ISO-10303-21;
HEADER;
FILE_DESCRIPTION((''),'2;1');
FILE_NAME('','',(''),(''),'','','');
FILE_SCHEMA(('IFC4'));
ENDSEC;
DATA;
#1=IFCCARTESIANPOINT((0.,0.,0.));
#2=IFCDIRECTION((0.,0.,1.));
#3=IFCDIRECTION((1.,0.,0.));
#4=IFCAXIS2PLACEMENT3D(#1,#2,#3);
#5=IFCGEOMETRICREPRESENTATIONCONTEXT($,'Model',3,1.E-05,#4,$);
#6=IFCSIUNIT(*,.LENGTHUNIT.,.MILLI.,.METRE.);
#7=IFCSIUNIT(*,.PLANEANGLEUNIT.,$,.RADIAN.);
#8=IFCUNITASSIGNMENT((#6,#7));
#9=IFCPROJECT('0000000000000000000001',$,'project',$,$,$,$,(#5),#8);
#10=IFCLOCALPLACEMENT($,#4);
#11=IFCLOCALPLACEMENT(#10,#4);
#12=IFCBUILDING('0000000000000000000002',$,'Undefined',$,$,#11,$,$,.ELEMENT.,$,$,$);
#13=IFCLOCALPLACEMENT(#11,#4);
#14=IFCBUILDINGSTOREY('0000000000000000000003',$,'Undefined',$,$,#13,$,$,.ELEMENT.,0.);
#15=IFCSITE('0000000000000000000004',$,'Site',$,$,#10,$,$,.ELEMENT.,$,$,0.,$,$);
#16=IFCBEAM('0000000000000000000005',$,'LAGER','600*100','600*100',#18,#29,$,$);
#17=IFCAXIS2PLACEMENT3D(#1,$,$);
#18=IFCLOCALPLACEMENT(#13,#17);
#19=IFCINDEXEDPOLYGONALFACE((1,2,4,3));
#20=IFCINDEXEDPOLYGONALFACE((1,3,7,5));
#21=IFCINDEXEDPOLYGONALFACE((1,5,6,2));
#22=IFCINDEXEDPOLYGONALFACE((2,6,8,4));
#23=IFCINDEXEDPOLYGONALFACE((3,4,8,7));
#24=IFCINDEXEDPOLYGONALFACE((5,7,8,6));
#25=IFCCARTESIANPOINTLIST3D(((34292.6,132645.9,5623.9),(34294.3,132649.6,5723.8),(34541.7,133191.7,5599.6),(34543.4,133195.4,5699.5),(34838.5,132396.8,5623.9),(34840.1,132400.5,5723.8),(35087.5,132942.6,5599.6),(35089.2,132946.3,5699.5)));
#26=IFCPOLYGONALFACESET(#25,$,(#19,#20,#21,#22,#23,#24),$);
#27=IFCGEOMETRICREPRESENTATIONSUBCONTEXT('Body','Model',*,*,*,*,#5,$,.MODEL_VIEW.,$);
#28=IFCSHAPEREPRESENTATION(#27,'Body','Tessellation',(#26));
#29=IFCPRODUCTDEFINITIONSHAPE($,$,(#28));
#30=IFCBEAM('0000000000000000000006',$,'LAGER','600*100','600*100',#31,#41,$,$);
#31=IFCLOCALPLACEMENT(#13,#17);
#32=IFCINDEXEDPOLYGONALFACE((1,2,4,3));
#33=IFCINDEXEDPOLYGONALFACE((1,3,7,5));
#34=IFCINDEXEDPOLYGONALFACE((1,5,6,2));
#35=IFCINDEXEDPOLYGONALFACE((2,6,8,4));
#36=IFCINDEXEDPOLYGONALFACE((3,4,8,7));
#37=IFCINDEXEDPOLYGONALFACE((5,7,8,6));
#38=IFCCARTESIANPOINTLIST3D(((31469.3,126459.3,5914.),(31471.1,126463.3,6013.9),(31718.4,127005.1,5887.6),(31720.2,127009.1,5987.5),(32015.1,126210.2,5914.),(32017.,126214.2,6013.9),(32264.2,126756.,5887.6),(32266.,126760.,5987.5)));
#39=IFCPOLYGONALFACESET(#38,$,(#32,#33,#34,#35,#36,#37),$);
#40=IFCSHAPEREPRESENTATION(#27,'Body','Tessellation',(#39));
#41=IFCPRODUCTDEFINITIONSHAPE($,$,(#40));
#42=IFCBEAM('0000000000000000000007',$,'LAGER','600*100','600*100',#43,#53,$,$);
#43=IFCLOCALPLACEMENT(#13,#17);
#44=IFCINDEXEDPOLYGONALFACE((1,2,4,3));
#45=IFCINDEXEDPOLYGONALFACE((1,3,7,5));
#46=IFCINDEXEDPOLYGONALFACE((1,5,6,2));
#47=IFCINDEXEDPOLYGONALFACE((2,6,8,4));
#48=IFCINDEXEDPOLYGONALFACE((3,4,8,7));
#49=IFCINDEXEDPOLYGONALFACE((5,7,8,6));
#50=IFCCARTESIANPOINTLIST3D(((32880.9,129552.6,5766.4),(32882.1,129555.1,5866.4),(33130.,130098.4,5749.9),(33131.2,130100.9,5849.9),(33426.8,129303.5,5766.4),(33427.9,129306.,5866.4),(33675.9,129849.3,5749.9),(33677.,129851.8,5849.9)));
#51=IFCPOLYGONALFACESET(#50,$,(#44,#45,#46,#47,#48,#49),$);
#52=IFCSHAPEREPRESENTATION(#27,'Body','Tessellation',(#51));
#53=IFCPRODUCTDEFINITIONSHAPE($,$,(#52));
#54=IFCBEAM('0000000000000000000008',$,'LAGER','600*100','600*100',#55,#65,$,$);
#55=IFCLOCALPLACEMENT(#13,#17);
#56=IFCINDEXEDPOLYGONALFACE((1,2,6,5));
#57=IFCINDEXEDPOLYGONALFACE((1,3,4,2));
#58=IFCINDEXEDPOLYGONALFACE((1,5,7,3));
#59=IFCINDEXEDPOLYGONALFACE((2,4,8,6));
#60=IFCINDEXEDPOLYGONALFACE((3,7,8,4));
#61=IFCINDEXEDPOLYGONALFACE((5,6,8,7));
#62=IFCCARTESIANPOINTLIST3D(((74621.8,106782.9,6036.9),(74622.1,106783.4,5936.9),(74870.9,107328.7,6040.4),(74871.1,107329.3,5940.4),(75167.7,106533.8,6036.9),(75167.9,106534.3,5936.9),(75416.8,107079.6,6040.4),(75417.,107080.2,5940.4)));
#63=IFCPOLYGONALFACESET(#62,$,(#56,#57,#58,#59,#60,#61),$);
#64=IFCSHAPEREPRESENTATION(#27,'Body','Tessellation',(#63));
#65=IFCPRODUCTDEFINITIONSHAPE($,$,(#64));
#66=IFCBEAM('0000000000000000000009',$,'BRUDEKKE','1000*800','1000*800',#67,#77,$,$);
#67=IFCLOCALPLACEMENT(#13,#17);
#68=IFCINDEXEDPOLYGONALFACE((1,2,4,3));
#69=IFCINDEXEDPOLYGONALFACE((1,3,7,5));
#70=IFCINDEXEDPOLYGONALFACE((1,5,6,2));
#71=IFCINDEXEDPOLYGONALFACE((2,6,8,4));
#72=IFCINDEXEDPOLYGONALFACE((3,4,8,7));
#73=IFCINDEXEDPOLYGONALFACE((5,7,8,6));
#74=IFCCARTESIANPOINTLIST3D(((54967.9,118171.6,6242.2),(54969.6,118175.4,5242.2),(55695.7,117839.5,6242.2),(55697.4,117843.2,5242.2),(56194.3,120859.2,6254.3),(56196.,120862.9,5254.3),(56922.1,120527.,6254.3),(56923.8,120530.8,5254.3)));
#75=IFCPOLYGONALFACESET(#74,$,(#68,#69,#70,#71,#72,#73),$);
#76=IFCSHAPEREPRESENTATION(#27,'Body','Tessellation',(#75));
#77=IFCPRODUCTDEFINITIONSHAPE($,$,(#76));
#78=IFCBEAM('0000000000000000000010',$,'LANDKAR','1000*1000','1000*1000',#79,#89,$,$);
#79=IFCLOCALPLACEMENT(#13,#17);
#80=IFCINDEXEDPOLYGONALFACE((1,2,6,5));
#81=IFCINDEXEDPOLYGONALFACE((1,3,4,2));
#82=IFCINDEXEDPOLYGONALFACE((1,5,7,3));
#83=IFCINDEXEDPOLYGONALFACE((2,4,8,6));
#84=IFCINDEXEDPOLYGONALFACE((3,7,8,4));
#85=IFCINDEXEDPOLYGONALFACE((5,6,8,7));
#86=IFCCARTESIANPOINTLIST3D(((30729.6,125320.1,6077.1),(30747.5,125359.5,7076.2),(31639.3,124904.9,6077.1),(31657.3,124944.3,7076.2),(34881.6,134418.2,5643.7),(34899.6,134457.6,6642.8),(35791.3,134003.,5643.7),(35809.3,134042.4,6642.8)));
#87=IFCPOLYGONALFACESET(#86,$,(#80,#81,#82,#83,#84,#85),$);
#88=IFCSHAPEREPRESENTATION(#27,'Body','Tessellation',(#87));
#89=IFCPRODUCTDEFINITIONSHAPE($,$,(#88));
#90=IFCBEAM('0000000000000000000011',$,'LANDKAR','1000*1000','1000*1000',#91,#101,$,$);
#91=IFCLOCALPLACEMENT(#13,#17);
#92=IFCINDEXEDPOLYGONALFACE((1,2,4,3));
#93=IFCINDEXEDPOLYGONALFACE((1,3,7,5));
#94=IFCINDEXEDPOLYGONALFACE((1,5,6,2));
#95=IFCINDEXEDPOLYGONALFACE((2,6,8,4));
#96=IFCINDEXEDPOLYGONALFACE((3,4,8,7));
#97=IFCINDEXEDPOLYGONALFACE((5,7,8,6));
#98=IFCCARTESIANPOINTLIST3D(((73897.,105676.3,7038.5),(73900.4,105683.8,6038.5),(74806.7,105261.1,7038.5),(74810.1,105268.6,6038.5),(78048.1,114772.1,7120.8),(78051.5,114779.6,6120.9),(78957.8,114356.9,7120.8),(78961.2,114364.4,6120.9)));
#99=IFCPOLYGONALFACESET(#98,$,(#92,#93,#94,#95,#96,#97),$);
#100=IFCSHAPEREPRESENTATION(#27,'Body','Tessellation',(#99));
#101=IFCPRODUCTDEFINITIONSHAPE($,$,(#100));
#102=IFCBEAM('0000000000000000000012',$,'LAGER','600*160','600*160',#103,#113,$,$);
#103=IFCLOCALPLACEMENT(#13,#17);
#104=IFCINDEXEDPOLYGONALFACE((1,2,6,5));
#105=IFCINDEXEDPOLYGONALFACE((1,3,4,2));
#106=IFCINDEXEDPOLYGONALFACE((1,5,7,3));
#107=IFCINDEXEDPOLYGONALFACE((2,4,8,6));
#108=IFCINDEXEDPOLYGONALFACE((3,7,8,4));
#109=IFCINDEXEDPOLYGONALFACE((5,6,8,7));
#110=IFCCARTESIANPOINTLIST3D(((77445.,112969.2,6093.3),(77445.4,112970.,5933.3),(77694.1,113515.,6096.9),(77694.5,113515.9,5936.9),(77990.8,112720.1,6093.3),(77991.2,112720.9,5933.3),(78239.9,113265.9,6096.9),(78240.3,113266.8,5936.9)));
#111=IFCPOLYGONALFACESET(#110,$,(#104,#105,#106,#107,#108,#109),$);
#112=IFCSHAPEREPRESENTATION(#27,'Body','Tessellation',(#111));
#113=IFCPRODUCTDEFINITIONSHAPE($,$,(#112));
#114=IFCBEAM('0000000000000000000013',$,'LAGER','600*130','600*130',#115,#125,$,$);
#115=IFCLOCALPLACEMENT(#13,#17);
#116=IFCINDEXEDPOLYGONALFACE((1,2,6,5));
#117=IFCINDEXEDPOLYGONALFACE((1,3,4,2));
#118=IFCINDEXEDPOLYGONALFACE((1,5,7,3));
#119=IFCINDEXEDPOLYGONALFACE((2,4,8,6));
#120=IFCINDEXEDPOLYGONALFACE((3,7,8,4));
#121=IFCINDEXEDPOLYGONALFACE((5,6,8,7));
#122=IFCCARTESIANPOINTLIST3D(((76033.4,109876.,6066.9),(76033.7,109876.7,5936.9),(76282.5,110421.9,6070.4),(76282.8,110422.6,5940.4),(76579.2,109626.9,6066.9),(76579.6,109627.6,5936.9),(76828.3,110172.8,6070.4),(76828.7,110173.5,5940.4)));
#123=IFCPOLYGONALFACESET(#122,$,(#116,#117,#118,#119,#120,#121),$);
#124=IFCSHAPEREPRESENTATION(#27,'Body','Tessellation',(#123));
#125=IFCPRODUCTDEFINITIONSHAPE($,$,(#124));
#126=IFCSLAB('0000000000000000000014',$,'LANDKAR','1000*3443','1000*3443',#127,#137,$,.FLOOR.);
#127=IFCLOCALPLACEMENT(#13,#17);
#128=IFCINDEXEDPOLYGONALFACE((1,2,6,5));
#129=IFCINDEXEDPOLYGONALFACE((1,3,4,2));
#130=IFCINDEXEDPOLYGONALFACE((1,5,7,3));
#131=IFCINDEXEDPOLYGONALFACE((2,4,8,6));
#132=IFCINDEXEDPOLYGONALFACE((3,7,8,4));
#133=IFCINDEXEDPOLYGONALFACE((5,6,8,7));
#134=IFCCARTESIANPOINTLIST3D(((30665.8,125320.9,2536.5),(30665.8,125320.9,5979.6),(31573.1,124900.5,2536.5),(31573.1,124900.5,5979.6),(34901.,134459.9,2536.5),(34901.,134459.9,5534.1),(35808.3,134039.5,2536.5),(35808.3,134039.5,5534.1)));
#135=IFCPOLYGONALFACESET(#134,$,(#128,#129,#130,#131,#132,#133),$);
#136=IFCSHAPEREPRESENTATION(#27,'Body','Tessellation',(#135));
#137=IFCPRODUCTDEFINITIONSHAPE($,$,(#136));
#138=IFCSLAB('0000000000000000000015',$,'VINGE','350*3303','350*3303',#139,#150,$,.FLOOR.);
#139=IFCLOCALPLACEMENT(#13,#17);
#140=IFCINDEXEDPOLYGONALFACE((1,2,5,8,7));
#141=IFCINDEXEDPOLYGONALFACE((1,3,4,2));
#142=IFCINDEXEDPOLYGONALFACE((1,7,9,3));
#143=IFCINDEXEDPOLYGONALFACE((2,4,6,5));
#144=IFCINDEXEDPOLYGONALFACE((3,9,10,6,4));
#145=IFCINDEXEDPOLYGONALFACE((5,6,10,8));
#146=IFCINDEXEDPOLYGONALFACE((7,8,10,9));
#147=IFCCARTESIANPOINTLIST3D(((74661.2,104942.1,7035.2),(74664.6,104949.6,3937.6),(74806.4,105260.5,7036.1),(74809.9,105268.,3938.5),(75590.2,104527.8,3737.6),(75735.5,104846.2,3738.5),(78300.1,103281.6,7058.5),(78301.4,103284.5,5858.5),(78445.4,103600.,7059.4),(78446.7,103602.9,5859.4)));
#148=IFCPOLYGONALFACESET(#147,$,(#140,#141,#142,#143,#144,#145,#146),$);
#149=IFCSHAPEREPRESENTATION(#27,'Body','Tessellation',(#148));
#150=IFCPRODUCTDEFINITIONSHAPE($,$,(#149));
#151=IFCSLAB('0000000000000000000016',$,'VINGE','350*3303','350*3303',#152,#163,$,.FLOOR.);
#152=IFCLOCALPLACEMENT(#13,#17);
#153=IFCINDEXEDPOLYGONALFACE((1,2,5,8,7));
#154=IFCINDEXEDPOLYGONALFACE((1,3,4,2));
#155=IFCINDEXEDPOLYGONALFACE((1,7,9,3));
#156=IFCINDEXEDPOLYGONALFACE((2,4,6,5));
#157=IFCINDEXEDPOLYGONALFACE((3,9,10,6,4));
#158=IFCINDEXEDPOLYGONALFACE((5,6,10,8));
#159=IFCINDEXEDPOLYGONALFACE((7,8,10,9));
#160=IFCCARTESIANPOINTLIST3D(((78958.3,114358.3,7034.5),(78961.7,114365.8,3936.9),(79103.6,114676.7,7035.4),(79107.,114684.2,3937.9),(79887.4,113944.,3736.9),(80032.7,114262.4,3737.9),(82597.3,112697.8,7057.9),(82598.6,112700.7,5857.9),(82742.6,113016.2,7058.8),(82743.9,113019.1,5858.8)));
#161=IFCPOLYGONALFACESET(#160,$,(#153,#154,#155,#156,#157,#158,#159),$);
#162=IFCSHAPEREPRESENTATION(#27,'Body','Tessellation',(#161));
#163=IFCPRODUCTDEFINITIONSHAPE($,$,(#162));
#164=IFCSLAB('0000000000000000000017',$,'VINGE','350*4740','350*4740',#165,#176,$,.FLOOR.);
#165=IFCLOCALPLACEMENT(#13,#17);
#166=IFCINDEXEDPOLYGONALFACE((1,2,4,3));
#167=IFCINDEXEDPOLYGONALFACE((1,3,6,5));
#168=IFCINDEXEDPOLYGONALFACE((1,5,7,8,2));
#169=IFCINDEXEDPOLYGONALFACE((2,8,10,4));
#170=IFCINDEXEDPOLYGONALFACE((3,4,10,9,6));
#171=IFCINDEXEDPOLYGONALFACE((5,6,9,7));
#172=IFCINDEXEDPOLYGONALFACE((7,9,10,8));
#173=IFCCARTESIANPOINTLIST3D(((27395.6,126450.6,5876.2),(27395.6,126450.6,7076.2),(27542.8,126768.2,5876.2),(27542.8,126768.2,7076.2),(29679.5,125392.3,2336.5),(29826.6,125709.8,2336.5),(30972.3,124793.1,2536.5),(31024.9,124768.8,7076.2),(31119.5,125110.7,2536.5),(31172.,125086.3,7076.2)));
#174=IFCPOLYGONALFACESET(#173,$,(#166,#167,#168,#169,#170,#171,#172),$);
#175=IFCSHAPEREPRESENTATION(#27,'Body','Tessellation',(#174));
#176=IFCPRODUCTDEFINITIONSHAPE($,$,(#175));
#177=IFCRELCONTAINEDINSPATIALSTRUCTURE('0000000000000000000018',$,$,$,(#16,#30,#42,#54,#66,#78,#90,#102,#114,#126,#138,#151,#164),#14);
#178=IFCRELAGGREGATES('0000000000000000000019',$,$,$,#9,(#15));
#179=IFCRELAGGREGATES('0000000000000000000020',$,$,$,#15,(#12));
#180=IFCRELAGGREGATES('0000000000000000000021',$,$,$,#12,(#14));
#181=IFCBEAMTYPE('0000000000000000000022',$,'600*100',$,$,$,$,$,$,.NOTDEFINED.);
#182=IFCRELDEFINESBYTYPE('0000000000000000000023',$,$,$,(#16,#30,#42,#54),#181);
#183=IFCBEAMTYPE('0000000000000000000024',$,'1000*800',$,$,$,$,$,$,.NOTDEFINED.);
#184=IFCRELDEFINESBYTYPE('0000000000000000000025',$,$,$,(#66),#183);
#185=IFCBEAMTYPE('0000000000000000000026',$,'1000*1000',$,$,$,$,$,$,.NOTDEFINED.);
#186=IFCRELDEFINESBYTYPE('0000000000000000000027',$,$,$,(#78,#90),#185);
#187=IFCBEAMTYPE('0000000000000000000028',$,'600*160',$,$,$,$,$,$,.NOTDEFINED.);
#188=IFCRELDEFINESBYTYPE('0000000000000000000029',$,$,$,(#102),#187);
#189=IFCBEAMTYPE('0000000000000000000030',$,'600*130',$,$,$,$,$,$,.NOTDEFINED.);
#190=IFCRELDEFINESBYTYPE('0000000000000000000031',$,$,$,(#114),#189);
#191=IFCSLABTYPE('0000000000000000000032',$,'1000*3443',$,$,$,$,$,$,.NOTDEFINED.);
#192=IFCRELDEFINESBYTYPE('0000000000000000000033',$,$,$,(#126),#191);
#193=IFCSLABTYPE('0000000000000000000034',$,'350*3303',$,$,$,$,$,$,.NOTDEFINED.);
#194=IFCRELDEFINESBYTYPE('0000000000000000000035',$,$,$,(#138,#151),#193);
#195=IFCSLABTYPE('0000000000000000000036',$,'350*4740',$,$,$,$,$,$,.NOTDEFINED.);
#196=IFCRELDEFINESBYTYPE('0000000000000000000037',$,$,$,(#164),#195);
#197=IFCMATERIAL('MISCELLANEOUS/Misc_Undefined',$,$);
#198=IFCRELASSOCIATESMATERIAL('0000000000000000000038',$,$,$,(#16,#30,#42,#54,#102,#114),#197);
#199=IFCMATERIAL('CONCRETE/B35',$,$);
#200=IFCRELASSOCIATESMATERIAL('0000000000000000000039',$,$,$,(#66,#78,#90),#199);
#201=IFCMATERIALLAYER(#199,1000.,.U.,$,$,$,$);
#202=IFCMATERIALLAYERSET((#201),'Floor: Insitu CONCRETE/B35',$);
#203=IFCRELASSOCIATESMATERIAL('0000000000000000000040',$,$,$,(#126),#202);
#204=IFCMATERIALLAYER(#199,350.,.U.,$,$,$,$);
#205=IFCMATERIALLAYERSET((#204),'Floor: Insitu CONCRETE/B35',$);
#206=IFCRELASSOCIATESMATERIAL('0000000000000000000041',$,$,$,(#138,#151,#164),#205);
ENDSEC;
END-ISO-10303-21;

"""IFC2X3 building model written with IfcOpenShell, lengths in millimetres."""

from ifc_helpers import new_model, si_unit, frame, origin_with_axes, origin_2d_with_axis, place, context, subcontext, project, spatial, polyline, rectangle, outline, extrude, material, layer, layer_set, layer_usage, type_object, element, save


model = new_model("IFC2X3")

# Units and contexts
model_context = context("Model", 3, precision=1e-05, world=origin_with_axes())
body_context = subcontext(model_context, "Body", "Model", "MODEL_VIEW")
ifc_project = project(units=[si_unit("LENGTHUNIT", "METRE", prefix="MILLI"), si_unit("PLANEANGLEUNIT", "RADIAN")], contexts=[model_context])

# Site, building, storey
site_placement = place(None, origin_with_axes())
site = spatial("IfcSite", under=ifc_project, at=site_placement, Name="Site", CompositionType="ELEMENT", RefElevation=0.0)
building_placement = place(site_placement, origin_with_axes())
building = spatial("IfcBuilding", under=site, at=building_placement, Name="Undefined", CompositionType="ELEMENT")
storey_placement = place(building_placement, origin_with_axes())
storey = spatial("IfcBuildingStorey", under=building, at=storey_placement, Name="Undefined", CompositionType="ELEMENT", Elevation=0.0)

# Shared definitions
ifc_material_1 = material(Name="CONCRETE/B35")

# Beams
ifc_material_2 = material(Name="MISCELLANEOUS/Misc_Undefined")
beam_type_1 = type_object("IfcBeamType", Name="600*100", PredefinedType="NOTDEFINED")
beam_1_placement = place(storey_placement, frame((34566.4, 132523.2, 5673.9), z_axis=(-0.90975, 0.415157, 0.0), x_axis=(0.414817, 0.909004, -0.040476)))
element("IfcBeam", 1, at=beam_1_placement, inside=storey, type_object=beam_type_1, material=ifc_material_2, Name="LAGER", Description="600*100", ObjectType="600*100", context=body_context, shape_type="SweptSolid", body=[
    extrude(rectangle(XDim=100.0, YDim=600.0, at=origin_2d_with_axis()), frame((600.5, 0.0, 0.0), z_axis=(-1.0, 0.0, 0.0), x_axis=(0.0, -1.0, 0.0)), (0.0, 0.0, 1.0), 600.5),
])
beam_2_placement = place(storey_placement, frame((31743.1, 126336.7, 5963.9), z_axis=(-0.90975, 0.415157, 0.0), x_axis=(0.414758, 0.908875, -0.043844)))
element("IfcBeam", 2, at=beam_2_placement, inside=storey, type_object=beam_type_1, material=ifc_material_2, Name="LAGER", Description="600*100", ObjectType="600*100", context=body_context, shape_type="SweptSolid", body=[
    extrude(rectangle(XDim=100.0, YDim=600.0, at=origin_2d_with_axis()), frame((600.6, 0.0, 0.0), z_axis=(-1.0, 0.0, 0.0), x_axis=(0.0, -1.0, 0.0)), (0.0, 0.0, 1.0), 600.6),
])
beam_3_placement = place(storey_placement, frame((33154.4, 129429.3, 5816.4), z_axis=(-0.90975, 0.415157, 0.0), x_axis=(0.415001, 0.909407, -0.027434)))
element("IfcBeam", 3, at=beam_3_placement, inside=storey, type_object=beam_type_1, material=ifc_material_2, Name="LAGER", Description="600*100", ObjectType="600*100", context=body_context, shape_type="SweptSolid", body=[
    extrude(rectangle(XDim=100.0, YDim=600.0, at=origin_2d_with_axis()), frame((600.2, 0.0, 0.0), z_axis=(-1.0, 0.0, 0.0), x_axis=(0.0, -1.0, 0.0)), (0.0, 0.0, 1.0), 600.2),
])
beam_4_placement = place(storey_placement, frame((74894.9, 106658.6, 5986.9), z_axis=(-0.90975, 0.415157, 0.0), x_axis=(0.41515, 0.909734, 0.005889)))
element("IfcBeam", 4, at=beam_4_placement, inside=storey, type_object=beam_type_1, material=ifc_material_2, Name="LAGER", Description="600*100", ObjectType="600*100", context=body_context, shape_type="SweptSolid", body=[
    extrude(rectangle(XDim=100.0, YDim=600.0, at=origin_2d_with_axis()), frame((600.0, 0.0, 0.0), z_axis=(-1.0, 0.0, 0.0), x_axis=(0.0, -1.0, 0.0)), (0.0, 0.0, 1.0), 600.0),
])
beam_type_2 = type_object("IfcBeamType", Name="1000*800", PredefinedType="NOTDEFINED")
beam_5_placement = place(storey_placement, frame((55332.6, 118007.4, 5742.2), z_axis=(-0.001706, -0.003738, 0.999992), x_axis=(0.415154, 0.909742, 0.004109)))
element("IfcBeam", 5, at=beam_5_placement, inside=storey, type_object=beam_type_2, material=ifc_material_1, Name="BRUDEKKE", Description="1000*800", ObjectType="1000*800", context=body_context, shape_type="SweptSolid", body=[
    extrude(rectangle(XDim=800.0, YDim=1000.0, at=origin_2d_with_axis()), frame((2954.2, 0.0, 0.0), z_axis=(-1.0, 0.0, 0.0), x_axis=(0.0, -1.0, 0.0)), (0.0, 0.0, 1.0), 2954.2),
])
beam_type_3 = type_object("IfcBeamType", Name="1000*1000", PredefinedType="NOTDEFINED")
beam_6_placement = place(storey_placement, frame((35345.4, 134230.3, 6143.3), z_axis=(0.017975, 0.039387, 0.999062), x_axis=(-0.414781, -0.908891, 0.043295)))
element("IfcBeam", 6, at=beam_6_placement, inside=storey, type_object=beam_type_3, material=ifc_material_1, Name="LANDKAR", Description="1000*1000", ObjectType="1000*1000", context=body_context, shape_type="SweptSolid", body=[
    extrude(rectangle(XDim=1000.0, YDim=1000.0, at=origin_2d_with_axis()), frame((10010.1, 0.0, 0.0), z_axis=(-1.0, 0.0, 0.0), x_axis=(0.0, -1.0, 0.0)), (0.0, 0.0, 1.0), 10010.1),
])
beam_7_placement = place(storey_placement, frame((74353.6, 105472.5, 6538.5), z_axis=(-0.003421, -0.007496, 0.999966), x_axis=(0.415166, 0.909708, 0.008239)))
element("IfcBeam", 7, at=beam_7_placement, inside=storey, type_object=beam_type_3, material=ifc_material_1, Name="LANDKAR", Description="1000*1000", ObjectType="1000*1000", context=body_context, shape_type="SweptSolid", body=[
    extrude(rectangle(XDim=1000.0, YDim=1000.0, at=origin_2d_with_axis()), frame((9998.6, 0.0, 0.0), z_axis=(-1.0, 0.0, 0.0), x_axis=(0.0, -1.0, 0.0)), (0.0, 0.0, 1.0), 9998.6),
])
beam_type_4 = type_object("IfcBeamType", Name="600*160", PredefinedType="NOTDEFINED")
beam_8_placement = place(storey_placement, frame((77718.1, 112845.0, 6013.3), z_axis=(-0.90975, 0.415157, 0.0), x_axis=(0.41515, 0.909734, 0.005889)))
element("IfcBeam", 8, at=beam_8_placement, inside=storey, type_object=beam_type_4, material=ifc_material_2, Name="LAGER", Description="600*160", ObjectType="600*160", context=body_context, shape_type="SweptSolid", body=[
    extrude(rectangle(XDim=160.0, YDim=600.0, at=origin_2d_with_axis()), frame((600.0, 0.0, 0.0), z_axis=(-1.0, 0.0, 0.0), x_axis=(0.0, -1.0, 0.0)), (0.0, 0.0, 1.0), 600.0),
])
beam_type_5 = type_object("IfcBeamType", Name="600*130", PredefinedType="NOTDEFINED")
beam_9_placement = place(storey_placement, frame((76306.5, 109751.8, 6001.9), z_axis=(-0.90975, 0.415157, 0.0), x_axis=(0.41515, 0.909734, 0.005889)))
element("IfcBeam", 9, at=beam_9_placement, inside=storey, type_object=beam_type_5, material=ifc_material_2, Name="LAGER", Description="600*130", ObjectType="600*130", context=body_context, shape_type="SweptSolid", body=[
    extrude(rectangle(XDim=130.0, YDim=600.0, at=origin_2d_with_axis()), frame((600.0, 0.0, 0.0), z_axis=(-1.0, 0.0, 0.0), x_axis=(0.0, -1.0, 0.0)), (0.0, 0.0, 1.0), 600.0),
])

# Slabs
ifc_layer_1 = layer(ifc_material_1, 1000.0, ventilated="UNKNOWN")
ifc_layer_set_1 = layer_set([ifc_layer_1], Name="Floor: Insitu CONCRETE/B35")
ifc_layer_usage_1 = layer_usage(ifc_layer_set_1, "AXIS3", "POSITIVE", -500.0)
slab_type_1 = type_object("IfcSlabType", Name="1000*3443", PredefinedType="NOTDEFINED")
slab_1_placement = place(storey_placement, frame((31119.5, 125110.7, 2536.5), z_axis=(0.907309, -0.420464, 0.0), x_axis=(0.420464, 0.907309, 0.000004)))
element("IfcSlab", 10, at=slab_1_placement, inside=storey, type_object=slab_type_1, material=ifc_layer_usage_1, Name="LANDKAR", Description="1000*3443", ObjectType="1000*3443", PredefinedType="FLOOR", context=body_context, shape_type="SweptSolid", body=[
    extrude(outline(polyline([(0.0, 0.0), (10072.7, 0.0), (10072.7, 2997.6), (0.0, 3443.1), (0.0, 0.0)])), frame((0.0, 0.0, -500.0), z_axis=(0.0, 0.0, 1.0), x_axis=(1.0, 0.0, 0.0)), (0.0, 0.0, 1.0), 1000.0),
])
ifc_layer_2 = layer(ifc_material_1, 350.0, ventilated="UNKNOWN")
ifc_layer_set_2 = layer_set([ifc_layer_2], Name="Floor: Insitu CONCRETE/B35")
ifc_layer_usage_2 = layer_usage(ifc_layer_set_2, "AXIS3", "POSITIVE", -175.0)
slab_type_2 = type_object("IfcSlabType", Name="350*3303", PredefinedType="NOTDEFINED")
slab_2_placement = place(storey_placement, frame((74737.2, 105108.8, 3938.0), z_axis=(-0.415122, -0.909762, -0.002659), x_axis=(0.892889, -0.406859, -0.19291)))
element("IfcSlab", 11, at=slab_2_placement, inside=storey, type_object=slab_type_2, material=ifc_layer_usage_2, Name="VINGE", Description="350*3303", ObjectType="350*3303", PredefinedType="FLOOR", context=body_context, shape_type="SweptSolid", body=[
    extrude(outline(polyline([(0.0, 0.0), (1036.7, 0.0), (3554.2, 2656.5), (3322.7, 3834.0), (-597.6, 3039.4), (0.0, 0.0)])), frame((0.0, 0.0, -175.0), z_axis=(0.0, 0.0, 1.0), x_axis=(1.0, 0.0, 0.0)), (0.0, 0.0, 1.0), 350.0),
])
ifc_layer_usage_3 = layer_usage(ifc_layer_set_2, "AXIS3", "POSITIVE", -175.0)
slab_3_placement = place(storey_placement, frame((79034.4, 114525.0, 3937.4), z_axis=(-0.415122, -0.909762, -0.002659), x_axis=(0.892889, -0.406859, -0.19291)))
element("IfcSlab", 12, at=slab_3_placement, inside=storey, type_object=slab_type_2, material=ifc_layer_usage_3, Name="VINGE", Description="350*3303", ObjectType="350*3303", PredefinedType="FLOOR", context=body_context, shape_type="SweptSolid", body=[
    extrude(outline(polyline([(0.0, 0.0), (1036.7, 0.0), (3554.2, 2656.5), (3322.7, 3834.0), (-597.6, 3039.4), (0.0, 0.0)])), frame((0.0, 0.0, -175.0), z_axis=(0.0, 0.0, 1.0), x_axis=(1.0, 0.0, 0.0)), (0.0, 0.0, 1.0), 350.0),
])
ifc_layer_usage_4 = layer_usage(ifc_layer_set_2, "AXIS3", "POSITIVE", -175.0)
slab_type_3 = type_object("IfcSlabType", Name="350*4740", PredefinedType="NOTDEFINED")
slab_4_placement = place(storey_placement, frame((31045.9, 124951.9, 2536.5), z_axis=(-0.420464, -0.907309, 0.0), x_axis=(0.011579, -0.005366, 0.999919)))
element("IfcSlab", 13, at=slab_4_placement, inside=storey, type_object=slab_type_3, material=ifc_layer_usage_4, Name="VINGE", Description="350*4740", ObjectType="350*4740", PredefinedType="FLOOR", context=body_context, shape_type="SweptSolid", body=[
    extrude(outline(polyline([(0.0, 0.0), (4540.0, 0.0), (4489.0, 3999.7), (3289.1, 3984.4), (-218.2, 1422.2), (0.0, 0.0)])), frame((0.0, 0.0, -175.0), z_axis=(0.0, 0.0, 1.0), x_axis=(1.0, 0.0, 0.0)), (0.0, 0.0, 1.0), 350.0),
])

save(model, "model.ifc")
